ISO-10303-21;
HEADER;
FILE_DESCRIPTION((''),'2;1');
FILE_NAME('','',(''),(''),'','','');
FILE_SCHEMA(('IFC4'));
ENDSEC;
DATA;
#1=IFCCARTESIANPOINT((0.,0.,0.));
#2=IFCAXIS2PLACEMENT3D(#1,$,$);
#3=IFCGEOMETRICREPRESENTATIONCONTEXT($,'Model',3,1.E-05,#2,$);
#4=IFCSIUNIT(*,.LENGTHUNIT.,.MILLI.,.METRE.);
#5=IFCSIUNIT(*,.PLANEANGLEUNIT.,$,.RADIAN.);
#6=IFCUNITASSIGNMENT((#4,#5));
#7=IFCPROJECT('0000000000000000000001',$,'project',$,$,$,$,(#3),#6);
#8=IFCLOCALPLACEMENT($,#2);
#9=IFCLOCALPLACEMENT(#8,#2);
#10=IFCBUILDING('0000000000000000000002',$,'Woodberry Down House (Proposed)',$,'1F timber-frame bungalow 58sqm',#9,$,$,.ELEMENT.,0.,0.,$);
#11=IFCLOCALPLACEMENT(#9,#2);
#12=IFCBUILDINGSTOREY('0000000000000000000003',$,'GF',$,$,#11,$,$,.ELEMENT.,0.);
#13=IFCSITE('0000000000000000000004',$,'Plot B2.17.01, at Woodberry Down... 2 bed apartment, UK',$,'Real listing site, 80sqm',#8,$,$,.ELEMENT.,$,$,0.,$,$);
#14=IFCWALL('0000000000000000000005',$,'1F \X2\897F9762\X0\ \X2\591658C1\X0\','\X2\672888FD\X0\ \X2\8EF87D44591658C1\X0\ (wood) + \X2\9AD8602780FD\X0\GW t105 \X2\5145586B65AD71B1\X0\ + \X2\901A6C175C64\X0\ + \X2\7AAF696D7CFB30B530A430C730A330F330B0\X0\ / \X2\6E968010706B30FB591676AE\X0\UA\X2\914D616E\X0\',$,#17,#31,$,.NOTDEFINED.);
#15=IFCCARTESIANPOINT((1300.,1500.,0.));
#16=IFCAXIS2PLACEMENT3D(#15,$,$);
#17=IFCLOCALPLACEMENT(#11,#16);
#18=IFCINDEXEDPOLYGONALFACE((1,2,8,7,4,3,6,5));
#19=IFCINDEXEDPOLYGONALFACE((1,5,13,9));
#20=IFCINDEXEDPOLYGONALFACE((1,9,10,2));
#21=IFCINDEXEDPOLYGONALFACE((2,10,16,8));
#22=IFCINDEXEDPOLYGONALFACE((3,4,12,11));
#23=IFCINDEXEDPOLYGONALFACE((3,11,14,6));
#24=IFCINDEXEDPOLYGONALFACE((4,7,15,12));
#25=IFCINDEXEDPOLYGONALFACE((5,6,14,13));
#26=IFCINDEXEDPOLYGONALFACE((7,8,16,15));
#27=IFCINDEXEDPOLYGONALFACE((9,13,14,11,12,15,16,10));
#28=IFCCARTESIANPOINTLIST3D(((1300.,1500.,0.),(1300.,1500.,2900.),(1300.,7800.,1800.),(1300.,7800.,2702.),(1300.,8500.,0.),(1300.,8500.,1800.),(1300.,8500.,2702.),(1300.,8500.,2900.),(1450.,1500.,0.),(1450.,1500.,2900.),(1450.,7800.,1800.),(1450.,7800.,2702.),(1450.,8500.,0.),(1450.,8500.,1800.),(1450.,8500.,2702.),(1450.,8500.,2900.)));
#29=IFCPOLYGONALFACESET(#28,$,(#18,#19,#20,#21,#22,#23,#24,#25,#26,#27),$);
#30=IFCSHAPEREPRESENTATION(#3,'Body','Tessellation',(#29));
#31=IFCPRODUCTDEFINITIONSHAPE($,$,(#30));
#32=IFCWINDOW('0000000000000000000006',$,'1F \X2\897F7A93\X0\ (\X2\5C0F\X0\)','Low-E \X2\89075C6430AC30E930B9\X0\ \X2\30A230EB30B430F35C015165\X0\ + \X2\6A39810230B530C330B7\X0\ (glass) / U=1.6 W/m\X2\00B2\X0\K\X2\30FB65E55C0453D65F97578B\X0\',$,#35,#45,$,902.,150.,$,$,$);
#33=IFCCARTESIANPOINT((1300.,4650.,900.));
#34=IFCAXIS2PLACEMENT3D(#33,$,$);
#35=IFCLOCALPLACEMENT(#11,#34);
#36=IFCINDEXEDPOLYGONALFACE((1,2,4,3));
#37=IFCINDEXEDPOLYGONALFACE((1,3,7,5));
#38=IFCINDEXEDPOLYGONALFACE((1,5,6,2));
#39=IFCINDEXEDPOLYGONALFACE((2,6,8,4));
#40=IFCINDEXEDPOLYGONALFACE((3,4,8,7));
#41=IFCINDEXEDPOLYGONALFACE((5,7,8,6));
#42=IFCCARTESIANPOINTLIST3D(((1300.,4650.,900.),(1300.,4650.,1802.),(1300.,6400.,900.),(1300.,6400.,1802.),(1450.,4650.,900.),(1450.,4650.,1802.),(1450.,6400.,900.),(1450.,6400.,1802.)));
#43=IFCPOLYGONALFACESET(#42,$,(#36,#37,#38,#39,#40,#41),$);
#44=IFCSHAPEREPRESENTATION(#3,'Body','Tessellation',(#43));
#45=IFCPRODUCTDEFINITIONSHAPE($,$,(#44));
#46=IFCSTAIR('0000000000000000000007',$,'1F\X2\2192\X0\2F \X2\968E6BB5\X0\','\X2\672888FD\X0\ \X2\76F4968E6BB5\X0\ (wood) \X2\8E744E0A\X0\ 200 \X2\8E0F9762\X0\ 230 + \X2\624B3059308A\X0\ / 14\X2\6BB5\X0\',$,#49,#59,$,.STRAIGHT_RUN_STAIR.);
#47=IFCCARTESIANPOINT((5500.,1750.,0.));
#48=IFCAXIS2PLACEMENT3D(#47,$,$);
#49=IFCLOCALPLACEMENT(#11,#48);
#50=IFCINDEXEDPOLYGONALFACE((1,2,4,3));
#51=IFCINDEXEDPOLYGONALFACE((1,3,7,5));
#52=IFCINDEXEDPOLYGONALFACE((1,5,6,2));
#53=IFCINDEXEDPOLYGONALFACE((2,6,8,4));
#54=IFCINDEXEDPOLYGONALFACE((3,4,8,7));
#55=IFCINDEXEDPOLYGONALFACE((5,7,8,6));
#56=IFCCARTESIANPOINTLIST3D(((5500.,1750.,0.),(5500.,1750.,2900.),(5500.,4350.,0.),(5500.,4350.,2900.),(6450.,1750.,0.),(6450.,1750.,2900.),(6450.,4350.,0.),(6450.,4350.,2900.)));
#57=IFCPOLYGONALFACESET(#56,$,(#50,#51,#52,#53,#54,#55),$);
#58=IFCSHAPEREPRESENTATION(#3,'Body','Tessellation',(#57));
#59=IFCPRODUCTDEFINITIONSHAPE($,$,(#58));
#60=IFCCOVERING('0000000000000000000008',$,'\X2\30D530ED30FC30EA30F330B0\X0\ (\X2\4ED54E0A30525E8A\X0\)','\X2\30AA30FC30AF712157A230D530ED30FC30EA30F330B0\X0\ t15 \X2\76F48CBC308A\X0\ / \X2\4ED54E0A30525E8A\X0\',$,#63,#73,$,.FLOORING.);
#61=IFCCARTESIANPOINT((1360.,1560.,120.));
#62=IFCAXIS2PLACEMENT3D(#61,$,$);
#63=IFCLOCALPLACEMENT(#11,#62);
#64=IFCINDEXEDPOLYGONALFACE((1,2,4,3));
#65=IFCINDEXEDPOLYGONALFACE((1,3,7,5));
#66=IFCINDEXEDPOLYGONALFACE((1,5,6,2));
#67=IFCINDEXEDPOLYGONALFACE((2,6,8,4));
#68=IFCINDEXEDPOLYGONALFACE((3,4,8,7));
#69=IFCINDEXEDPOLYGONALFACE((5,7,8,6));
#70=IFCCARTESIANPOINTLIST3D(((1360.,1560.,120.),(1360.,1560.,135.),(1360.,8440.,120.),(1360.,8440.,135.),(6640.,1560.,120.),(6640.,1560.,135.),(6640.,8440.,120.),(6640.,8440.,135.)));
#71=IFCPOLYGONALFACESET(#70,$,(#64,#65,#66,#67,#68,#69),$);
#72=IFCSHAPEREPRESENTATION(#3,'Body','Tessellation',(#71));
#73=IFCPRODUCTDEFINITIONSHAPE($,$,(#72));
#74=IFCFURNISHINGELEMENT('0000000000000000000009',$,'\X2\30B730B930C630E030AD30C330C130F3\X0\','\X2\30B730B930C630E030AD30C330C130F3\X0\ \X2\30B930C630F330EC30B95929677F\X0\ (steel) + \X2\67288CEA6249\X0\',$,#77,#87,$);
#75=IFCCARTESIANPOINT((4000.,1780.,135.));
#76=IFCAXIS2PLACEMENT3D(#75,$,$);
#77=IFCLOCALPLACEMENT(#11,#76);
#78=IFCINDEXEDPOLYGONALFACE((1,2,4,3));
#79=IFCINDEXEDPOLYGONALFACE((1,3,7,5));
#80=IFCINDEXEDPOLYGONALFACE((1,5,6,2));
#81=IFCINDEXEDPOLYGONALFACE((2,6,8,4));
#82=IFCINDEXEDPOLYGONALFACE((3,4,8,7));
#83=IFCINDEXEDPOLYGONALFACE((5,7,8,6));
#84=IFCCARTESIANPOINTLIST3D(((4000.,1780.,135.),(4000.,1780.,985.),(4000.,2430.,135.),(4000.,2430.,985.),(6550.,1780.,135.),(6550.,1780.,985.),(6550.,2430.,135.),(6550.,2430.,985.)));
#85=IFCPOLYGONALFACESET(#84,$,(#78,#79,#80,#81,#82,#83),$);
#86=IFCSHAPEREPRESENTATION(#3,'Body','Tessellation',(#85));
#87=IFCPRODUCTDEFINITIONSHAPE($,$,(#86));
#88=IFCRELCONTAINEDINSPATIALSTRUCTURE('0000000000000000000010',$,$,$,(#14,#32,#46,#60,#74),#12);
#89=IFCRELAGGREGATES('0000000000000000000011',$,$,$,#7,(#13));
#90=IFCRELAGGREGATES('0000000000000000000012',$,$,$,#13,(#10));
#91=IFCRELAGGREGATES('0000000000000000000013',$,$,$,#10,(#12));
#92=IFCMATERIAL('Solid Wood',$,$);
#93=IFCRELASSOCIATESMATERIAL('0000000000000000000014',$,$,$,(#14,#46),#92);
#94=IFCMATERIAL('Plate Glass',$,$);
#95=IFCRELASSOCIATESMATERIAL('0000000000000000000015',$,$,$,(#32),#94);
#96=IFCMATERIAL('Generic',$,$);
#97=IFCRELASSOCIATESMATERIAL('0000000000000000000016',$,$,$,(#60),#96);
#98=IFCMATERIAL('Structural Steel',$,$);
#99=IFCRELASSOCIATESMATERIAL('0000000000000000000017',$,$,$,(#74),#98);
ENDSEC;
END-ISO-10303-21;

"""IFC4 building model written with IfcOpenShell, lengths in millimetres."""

from ifc_helpers import new_model, si_unit, frame, frame_2d, origin, place, context, project, spatial, rectangle, extrude, material, element, fill, save


model = new_model("IFC4")

# Units and contexts
model_context = context("Model", 3, precision=1e-05, world=origin())
ifc_project = project(units=[si_unit("LENGTHUNIT", "METRE", prefix="MILLI"), si_unit("PLANEANGLEUNIT", "RADIAN")], contexts=[model_context])

# Site, building, storey
site_placement = place(None, origin())
site = spatial("IfcSite", under=ifc_project, at=site_placement, Name="Plot B2.17.01, at Woodberry Down... 2 bed apartment, UK", ObjectType="Real listing site, 80sqm", CompositionType="ELEMENT", RefElevation=0.0)
building_placement = place(site_placement, origin())
building = spatial("IfcBuilding", under=site, at=building_placement, Name="Woodberry Down House (Proposed)", ObjectType="1F timber-frame bungalow 58sqm", CompositionType="ELEMENT", ElevationOfRefHeight=0.0, ElevationOfTerrain=0.0)
storey_placement = place(building_placement, origin())
storey = spatial("IfcBuildingStorey", under=building, at=storey_placement, Name="GF", CompositionType="ELEMENT", Elevation=0.0)

# Shared definitions
ifc_material_1 = material(Name="Solid Wood")
ifc_material_2 = material(Name="Generic")

# Shared definitions
ifc_material_3 = material(Name="Plate Glass")

# Wall, opening, window
wall_1_placement = place(storey_placement, frame((1300.0, 1500.0, 0.0)))
wall_1 = element("IfcWall", 1, at=wall_1_placement, inside=storey, material=ifc_material_1, Name="1F 西面 外壁", Description="木製 軸組外壁 (wood) + 高性能GW t105 充填断熱 + 通気層 + 窯業系サイディング / 準耐火・外皮UA配慮", PredefinedType="NOTDEFINED", context=model_context, shape_type="SweptSolid", body=[
    extrude(rectangle(XDim=150.0, YDim=7000.0, at=frame_2d((75.0, 3500.0))), frame((1300.0, 1500.0, 0.0)), (0.0, 0.0, 1.0), 2900.0),
])
opening_1_placement = place(storey_placement, frame((1300.0, 4650.0, 900.0)))
opening_1 = element("IfcOpeningElement", 2, at=opening_1_placement, cuts=wall_1, PredefinedType="NOTDEFINED", context=model_context, shape_type="SweptSolid", body=[
    extrude(rectangle(XDim=150.0, YDim=1750.0, at=frame_2d((75.0, 875.0))), frame((1300.0, 4650.0, 900.0)), (0.0, 0.0, 1.0), 902.0),
])
window_1_placement = place(storey_placement, frame((1300.0, 4650.0, 900.0)))
window_1 = element("IfcWindow", 3, at=window_1_placement, inside=storey, material=ifc_material_3, Name="1F 西窓 (小)", Description="Low-E 複層ガラス アルゴン封入 + 樹脂サッシ (glass) / U=1.6 W/m²K・日射取得型", OverallHeight=902.0, OverallWidth=150.0, context=model_context, shape_type="SweptSolid", body=[
    extrude(rectangle(XDim=150.0, YDim=1750.0, at=frame_2d((75.0, 875.0))), frame((1300.0, 4650.0, 900.0)), (0.0, 0.0, 1.0), 902.0),
])
fill(opening_1, window_1)

# Stair
stair_placement = place(storey_placement, frame((5500.0, 1750.0, 0.0)))
element("IfcStair", 4, at=stair_placement, inside=storey, material=ifc_material_1, Name="1F→2F 階段", Description="木製 直階段 (wood) 蹴上 200 踏面 230 + 手すり / 14段", PredefinedType="STRAIGHT_RUN_STAIR", context=model_context, shape_type="SweptSolid", body=[
    extrude(rectangle(XDim=950.0, YDim=2600.0, at=frame_2d((475.0, 1300.0))), frame((5500.0, 1750.0, 0.0)), (0.0, 0.0, 1.0), 2900.0),
])

# Covering
covering_placement = place(storey_placement, frame((1360.0, 1560.0, 120.0)))
element("IfcCovering", 5, at=covering_placement, inside=storey, material=ifc_material_2, Name="フローリング (仕上げ床)", Description="オーク無垢フローリング t15 直貼り / 仕上げ床", PredefinedType="FLOORING", context=model_context, shape_type="SweptSolid", body=[
    extrude(rectangle(XDim=5280.0, YDim=6880.0, at=frame_2d((2640.0, 3440.0))), frame((1360.0, 1560.0, 120.0)), (0.0, 0.0, 1.0), 15.0),
])

# Furnishing element
ifc_material_4 = material(Name="Structural Steel")
furnishing_placement = place(storey_placement, frame((4000.0, 1780.0, 135.0)))
element("IfcFurnishingElement", 6, at=furnishing_placement, inside=storey, material=ifc_material_4, Name="システムキッチン", Description="システムキッチン ステンレス天板 (steel) + 木質扉", context=model_context, shape_type="SweptSolid", body=[
    extrude(rectangle(XDim=2550.0, YDim=650.0, at=frame_2d((1275.0, 325.0))), frame((4000.0, 1780.0, 135.0)), (0.0, 0.0, 1.0), 850.0),
])

save(model, "model.ifc")
